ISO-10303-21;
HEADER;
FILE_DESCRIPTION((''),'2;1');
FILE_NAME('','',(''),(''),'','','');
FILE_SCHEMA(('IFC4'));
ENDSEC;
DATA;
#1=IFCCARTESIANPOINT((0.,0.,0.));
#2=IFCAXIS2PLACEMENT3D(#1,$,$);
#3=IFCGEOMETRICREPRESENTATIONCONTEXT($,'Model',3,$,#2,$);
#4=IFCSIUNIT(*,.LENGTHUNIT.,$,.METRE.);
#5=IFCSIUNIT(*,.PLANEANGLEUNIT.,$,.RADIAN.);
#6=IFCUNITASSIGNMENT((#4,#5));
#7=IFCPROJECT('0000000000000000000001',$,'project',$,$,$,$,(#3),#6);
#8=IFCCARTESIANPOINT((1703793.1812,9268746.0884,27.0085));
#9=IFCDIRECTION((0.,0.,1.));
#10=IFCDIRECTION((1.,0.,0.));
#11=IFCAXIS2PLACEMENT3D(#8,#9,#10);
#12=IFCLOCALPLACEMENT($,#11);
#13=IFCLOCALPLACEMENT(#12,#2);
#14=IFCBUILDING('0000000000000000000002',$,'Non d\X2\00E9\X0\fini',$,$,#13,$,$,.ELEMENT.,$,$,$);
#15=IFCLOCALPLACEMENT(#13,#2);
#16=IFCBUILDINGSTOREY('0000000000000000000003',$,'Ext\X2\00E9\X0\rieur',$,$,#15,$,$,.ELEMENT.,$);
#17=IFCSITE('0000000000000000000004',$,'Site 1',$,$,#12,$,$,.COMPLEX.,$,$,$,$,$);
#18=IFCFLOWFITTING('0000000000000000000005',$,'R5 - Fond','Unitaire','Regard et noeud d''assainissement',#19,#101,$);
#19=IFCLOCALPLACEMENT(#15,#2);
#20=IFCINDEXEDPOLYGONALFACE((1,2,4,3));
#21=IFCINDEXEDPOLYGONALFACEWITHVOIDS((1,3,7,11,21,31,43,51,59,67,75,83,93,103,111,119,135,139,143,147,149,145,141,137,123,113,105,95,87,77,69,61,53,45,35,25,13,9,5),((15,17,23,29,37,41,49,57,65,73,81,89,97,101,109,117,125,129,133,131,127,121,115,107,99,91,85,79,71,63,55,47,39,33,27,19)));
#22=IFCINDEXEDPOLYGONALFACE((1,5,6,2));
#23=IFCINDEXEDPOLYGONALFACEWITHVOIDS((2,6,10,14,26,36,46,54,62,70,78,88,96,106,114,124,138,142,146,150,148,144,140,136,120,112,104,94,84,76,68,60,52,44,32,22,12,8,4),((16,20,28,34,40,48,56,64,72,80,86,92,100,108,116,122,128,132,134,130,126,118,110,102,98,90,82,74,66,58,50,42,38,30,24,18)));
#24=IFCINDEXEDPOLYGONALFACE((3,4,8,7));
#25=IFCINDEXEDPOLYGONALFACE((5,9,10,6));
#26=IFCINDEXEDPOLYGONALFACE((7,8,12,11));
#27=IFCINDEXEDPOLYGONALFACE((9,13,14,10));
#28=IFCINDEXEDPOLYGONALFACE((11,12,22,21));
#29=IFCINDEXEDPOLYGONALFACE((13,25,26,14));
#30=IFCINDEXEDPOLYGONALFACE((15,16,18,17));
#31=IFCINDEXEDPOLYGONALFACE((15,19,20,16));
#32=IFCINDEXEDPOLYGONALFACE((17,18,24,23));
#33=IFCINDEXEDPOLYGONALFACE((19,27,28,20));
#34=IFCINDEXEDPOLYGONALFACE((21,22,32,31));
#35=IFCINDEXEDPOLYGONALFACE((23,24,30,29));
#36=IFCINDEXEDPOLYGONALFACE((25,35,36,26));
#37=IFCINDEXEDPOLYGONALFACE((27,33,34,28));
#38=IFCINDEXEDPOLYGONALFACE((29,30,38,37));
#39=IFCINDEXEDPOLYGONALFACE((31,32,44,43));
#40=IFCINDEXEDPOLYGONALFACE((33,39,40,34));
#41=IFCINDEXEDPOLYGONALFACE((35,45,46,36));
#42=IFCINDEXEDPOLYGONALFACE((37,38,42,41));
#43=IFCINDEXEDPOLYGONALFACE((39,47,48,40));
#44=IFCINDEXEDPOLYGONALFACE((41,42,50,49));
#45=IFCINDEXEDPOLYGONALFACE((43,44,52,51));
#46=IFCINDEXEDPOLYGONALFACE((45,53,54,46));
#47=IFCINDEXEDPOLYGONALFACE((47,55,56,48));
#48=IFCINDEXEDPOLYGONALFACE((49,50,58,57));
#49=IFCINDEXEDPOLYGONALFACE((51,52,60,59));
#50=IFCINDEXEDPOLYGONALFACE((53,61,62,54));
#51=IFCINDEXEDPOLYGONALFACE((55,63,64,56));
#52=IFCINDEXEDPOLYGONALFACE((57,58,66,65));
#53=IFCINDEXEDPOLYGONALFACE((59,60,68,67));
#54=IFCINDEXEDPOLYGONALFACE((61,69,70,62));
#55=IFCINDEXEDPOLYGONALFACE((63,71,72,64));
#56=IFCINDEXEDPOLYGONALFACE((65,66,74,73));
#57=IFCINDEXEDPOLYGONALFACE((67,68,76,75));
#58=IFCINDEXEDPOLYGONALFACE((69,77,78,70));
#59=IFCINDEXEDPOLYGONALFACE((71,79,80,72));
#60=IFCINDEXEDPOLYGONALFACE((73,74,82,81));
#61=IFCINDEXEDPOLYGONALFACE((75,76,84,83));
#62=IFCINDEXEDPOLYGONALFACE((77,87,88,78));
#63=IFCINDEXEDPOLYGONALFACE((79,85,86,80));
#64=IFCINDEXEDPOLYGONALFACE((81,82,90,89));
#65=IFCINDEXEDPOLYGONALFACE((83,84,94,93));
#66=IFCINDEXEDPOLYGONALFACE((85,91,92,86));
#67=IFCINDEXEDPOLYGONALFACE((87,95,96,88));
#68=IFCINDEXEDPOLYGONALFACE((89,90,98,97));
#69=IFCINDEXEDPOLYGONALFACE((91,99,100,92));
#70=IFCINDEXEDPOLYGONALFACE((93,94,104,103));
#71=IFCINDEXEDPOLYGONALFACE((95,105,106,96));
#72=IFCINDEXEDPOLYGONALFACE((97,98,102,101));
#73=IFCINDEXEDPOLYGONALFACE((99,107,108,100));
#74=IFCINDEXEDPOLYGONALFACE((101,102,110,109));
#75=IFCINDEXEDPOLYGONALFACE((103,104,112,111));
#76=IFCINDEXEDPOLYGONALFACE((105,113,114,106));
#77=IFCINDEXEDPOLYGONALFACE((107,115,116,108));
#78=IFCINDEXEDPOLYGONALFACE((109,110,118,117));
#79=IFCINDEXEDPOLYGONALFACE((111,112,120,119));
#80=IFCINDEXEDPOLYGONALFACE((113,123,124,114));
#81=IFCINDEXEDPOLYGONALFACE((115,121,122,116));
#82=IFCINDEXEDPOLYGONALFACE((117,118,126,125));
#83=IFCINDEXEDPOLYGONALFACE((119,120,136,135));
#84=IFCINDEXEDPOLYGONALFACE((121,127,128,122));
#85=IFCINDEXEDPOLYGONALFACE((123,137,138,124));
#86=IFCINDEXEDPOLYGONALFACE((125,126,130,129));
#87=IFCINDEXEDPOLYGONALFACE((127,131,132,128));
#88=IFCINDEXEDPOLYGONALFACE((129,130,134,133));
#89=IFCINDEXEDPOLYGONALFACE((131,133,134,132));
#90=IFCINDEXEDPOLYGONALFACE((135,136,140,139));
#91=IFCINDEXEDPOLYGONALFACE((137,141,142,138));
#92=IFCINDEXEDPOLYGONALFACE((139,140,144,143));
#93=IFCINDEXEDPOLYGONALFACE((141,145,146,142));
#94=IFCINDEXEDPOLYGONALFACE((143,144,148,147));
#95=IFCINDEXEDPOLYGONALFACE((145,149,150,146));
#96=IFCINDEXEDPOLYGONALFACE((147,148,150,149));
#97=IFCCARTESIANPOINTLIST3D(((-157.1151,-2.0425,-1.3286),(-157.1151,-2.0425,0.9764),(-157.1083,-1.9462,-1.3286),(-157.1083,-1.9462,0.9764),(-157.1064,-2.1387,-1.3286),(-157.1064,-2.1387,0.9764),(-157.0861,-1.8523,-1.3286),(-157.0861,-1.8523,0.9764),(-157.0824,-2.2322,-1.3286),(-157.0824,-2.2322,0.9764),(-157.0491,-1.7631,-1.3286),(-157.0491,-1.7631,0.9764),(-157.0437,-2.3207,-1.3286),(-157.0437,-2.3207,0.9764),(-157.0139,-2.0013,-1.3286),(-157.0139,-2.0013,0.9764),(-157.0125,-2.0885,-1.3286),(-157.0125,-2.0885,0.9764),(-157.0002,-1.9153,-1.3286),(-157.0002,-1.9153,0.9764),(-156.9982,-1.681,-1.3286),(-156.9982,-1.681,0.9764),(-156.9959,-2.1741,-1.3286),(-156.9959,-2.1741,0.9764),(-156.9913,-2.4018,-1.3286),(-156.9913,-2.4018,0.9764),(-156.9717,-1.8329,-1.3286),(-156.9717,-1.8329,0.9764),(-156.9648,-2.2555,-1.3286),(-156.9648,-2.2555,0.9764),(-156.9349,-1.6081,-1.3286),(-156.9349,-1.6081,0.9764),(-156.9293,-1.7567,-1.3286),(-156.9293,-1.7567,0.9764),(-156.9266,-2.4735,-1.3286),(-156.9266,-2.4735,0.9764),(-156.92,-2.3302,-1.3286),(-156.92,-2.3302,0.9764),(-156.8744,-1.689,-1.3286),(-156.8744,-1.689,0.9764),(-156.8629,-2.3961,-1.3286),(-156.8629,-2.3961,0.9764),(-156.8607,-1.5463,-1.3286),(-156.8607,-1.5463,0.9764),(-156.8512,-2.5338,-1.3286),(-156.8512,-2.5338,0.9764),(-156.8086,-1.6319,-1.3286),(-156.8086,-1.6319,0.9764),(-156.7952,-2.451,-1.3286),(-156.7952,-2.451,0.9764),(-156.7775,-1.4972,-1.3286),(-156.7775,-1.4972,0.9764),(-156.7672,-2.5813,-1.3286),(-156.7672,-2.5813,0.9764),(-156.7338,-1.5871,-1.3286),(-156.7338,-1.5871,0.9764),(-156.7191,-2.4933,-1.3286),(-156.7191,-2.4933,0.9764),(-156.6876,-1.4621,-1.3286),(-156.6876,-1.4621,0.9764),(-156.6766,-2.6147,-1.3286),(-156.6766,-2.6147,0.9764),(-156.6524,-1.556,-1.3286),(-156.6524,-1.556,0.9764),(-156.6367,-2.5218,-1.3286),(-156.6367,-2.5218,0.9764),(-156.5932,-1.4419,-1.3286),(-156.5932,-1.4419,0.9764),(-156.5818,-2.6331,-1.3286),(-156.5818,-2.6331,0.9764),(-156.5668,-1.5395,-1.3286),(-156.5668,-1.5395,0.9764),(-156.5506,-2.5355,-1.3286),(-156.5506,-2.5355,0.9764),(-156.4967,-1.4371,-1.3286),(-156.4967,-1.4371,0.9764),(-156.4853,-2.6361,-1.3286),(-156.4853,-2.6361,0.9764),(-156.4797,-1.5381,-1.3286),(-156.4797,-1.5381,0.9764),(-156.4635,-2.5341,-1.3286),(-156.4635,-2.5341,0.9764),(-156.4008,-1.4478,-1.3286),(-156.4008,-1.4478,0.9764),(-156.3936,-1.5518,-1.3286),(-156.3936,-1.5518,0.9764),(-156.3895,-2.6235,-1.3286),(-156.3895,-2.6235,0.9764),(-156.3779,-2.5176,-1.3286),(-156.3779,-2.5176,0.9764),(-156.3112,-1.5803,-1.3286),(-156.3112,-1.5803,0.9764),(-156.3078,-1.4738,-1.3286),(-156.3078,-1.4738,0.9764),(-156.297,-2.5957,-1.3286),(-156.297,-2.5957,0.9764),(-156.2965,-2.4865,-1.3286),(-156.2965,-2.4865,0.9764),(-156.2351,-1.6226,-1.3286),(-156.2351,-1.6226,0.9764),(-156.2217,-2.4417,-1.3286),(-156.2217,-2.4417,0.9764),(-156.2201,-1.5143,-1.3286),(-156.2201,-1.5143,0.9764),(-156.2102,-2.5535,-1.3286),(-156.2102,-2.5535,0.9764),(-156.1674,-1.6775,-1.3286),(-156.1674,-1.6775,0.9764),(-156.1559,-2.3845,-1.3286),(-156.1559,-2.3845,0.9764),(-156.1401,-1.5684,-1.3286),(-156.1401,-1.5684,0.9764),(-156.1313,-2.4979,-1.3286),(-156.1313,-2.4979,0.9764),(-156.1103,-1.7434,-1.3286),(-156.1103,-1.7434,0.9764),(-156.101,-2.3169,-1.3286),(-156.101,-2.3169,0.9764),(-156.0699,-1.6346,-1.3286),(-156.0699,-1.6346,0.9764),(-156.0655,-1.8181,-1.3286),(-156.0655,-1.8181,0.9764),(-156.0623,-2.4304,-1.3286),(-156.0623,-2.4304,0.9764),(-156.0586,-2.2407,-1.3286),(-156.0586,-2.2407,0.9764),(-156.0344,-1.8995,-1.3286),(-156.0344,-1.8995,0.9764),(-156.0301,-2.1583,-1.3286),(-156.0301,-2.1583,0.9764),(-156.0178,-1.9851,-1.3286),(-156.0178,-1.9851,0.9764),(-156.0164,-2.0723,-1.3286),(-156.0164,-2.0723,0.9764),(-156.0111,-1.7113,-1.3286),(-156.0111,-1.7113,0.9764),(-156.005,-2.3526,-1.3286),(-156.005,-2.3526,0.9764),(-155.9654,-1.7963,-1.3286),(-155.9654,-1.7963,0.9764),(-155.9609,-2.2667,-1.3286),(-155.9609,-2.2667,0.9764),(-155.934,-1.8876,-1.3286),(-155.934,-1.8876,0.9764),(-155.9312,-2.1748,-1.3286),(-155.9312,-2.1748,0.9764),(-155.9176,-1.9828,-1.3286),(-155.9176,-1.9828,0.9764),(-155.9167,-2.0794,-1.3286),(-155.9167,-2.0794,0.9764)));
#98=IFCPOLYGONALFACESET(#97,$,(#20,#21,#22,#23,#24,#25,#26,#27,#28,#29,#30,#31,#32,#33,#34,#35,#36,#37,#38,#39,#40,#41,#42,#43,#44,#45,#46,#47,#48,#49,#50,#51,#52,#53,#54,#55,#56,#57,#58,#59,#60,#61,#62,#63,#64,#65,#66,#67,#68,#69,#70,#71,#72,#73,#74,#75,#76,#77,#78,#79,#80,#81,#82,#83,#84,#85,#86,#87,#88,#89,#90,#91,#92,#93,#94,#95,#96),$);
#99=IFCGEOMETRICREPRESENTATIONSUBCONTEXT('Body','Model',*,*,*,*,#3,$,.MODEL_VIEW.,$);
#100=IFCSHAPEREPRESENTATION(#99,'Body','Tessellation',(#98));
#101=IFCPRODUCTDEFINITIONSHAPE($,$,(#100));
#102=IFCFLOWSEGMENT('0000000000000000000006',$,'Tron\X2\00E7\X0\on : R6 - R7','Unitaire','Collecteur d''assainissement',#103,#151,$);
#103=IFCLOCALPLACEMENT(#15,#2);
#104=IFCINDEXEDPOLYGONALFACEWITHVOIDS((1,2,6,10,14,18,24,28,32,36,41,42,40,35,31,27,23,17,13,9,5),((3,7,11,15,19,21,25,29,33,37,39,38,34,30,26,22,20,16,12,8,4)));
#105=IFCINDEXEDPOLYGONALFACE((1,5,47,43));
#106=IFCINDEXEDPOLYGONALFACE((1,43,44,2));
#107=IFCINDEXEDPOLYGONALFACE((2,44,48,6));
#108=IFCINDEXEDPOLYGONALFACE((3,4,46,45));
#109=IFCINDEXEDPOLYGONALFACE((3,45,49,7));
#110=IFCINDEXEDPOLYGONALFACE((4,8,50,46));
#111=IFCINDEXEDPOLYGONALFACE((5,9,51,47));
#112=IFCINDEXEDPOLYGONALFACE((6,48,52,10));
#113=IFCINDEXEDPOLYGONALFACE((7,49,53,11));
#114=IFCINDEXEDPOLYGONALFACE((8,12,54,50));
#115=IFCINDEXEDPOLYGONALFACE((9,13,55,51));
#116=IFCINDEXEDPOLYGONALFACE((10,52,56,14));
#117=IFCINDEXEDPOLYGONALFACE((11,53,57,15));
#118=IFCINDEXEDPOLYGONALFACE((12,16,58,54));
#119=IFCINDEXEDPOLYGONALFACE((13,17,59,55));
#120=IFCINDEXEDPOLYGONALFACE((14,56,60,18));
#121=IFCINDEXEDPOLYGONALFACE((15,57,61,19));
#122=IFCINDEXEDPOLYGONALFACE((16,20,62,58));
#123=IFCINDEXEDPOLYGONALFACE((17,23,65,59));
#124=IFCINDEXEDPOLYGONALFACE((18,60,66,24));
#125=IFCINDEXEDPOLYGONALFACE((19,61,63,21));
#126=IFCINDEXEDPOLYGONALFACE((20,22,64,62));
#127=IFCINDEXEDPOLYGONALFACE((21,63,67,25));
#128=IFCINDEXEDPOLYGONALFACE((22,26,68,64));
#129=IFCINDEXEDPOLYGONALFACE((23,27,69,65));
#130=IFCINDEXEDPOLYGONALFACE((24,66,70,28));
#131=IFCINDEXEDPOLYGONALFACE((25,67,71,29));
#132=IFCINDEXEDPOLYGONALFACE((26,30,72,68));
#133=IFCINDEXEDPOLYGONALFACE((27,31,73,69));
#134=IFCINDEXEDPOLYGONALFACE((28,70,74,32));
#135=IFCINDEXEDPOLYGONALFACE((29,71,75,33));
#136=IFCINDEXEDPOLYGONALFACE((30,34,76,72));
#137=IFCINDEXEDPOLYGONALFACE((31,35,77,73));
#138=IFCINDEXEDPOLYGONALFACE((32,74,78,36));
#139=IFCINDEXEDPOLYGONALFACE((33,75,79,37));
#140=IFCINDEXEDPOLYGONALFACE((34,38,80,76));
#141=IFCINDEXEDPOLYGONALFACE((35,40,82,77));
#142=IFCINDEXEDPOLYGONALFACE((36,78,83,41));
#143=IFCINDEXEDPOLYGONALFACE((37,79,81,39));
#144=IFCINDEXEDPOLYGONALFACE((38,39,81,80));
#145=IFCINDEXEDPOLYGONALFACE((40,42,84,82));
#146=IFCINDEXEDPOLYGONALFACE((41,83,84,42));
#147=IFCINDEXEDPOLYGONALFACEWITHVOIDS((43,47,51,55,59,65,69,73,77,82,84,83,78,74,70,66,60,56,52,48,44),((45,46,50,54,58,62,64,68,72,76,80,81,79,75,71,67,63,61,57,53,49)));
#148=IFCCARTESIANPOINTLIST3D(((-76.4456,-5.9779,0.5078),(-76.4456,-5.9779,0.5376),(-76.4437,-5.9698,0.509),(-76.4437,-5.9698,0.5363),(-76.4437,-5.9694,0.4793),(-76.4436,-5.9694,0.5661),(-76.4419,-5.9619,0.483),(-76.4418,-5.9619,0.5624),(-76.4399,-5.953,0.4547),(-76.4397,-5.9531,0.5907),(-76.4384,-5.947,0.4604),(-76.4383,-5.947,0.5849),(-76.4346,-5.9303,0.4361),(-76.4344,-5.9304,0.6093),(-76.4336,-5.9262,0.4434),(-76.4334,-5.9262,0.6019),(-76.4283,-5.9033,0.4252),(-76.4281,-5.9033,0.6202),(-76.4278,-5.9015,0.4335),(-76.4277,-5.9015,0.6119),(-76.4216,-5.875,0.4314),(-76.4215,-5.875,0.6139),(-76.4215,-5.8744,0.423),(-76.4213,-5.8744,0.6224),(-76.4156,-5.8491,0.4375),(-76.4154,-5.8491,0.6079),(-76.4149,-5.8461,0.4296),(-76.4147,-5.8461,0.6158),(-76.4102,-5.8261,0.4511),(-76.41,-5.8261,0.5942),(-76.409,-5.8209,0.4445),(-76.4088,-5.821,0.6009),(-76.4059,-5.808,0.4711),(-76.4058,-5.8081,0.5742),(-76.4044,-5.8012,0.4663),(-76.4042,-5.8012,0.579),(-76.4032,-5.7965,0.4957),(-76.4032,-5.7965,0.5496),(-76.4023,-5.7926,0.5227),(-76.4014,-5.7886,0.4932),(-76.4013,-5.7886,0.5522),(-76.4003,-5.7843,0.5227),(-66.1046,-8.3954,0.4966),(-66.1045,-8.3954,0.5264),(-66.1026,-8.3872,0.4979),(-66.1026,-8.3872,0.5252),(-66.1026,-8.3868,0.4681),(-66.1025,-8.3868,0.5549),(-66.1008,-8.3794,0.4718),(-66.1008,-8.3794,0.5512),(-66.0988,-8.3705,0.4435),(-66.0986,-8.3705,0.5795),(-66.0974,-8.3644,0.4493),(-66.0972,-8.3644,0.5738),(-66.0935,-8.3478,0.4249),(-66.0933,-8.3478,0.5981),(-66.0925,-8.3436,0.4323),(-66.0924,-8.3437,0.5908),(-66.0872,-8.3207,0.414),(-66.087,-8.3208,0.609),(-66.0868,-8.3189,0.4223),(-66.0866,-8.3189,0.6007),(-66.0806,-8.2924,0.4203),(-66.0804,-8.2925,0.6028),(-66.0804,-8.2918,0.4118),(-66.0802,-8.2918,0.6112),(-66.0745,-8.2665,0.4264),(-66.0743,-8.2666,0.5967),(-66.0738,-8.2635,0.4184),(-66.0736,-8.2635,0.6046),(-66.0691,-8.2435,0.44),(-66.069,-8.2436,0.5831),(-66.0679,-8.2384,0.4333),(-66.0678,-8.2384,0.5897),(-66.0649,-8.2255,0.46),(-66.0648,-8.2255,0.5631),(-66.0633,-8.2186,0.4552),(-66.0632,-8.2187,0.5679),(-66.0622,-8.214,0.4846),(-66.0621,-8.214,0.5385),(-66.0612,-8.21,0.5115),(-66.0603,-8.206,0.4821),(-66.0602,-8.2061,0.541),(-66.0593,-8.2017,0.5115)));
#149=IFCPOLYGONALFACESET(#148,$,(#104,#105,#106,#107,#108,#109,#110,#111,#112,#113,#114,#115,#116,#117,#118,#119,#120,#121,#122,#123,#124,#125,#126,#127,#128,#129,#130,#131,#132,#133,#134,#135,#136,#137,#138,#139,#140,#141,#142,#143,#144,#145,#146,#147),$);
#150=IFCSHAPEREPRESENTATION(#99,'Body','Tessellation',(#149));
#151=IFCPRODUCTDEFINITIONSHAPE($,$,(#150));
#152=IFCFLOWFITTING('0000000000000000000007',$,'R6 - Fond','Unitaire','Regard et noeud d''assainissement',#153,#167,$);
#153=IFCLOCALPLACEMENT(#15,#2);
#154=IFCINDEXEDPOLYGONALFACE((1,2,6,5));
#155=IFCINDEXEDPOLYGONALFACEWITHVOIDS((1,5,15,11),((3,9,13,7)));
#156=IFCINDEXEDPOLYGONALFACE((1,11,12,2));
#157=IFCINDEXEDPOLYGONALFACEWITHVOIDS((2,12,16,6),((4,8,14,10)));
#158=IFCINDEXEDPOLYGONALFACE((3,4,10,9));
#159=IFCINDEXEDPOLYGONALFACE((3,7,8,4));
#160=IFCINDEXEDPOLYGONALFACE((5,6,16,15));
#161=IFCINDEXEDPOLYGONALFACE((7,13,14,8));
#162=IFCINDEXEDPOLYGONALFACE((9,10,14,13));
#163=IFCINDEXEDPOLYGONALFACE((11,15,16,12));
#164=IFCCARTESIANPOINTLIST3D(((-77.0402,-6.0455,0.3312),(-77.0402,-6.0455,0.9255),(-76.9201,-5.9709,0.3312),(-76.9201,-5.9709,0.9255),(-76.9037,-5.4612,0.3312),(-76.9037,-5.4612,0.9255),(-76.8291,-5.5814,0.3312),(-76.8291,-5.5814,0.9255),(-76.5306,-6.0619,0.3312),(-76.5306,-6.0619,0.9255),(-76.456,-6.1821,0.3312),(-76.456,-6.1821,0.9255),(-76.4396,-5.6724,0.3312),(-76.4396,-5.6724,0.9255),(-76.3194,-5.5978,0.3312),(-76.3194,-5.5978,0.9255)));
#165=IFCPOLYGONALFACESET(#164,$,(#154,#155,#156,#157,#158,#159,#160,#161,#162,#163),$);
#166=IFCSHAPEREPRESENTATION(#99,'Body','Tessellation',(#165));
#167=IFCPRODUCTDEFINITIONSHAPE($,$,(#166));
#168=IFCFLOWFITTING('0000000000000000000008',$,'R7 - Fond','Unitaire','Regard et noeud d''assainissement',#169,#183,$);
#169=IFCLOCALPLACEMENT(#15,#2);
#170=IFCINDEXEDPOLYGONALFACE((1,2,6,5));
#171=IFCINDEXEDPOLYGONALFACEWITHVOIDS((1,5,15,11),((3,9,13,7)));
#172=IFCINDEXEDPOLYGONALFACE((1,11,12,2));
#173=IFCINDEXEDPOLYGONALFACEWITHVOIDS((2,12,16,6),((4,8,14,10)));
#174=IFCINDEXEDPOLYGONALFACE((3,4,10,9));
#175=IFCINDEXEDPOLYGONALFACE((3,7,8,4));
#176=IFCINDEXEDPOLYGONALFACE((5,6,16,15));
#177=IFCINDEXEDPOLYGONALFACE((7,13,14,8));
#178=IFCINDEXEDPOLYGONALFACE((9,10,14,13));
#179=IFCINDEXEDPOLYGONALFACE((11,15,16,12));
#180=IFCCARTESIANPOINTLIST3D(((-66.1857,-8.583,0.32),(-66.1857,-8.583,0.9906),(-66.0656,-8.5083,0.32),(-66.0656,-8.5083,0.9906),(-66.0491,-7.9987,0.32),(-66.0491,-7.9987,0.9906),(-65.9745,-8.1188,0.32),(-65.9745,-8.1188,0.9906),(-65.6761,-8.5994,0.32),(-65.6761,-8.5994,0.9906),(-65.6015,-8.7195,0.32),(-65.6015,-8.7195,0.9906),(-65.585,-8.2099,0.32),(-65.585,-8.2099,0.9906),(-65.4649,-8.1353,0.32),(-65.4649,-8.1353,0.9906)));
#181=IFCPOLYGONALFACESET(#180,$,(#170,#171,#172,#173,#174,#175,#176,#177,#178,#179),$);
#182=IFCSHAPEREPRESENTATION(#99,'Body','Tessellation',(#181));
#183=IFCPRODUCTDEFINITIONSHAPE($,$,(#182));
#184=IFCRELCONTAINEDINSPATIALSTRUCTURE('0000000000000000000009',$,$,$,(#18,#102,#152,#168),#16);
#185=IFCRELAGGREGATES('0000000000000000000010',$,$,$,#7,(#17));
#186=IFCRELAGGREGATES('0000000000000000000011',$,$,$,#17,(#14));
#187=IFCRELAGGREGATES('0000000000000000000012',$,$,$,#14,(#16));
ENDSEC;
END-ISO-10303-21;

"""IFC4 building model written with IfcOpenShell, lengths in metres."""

from ifc_helpers import new_model, si_unit, frame, origin, origin_2d, place, context, subcontext, project, spatial, hollow_rectangle, hollow_circle, extrude, element, save


model = new_model("IFC4")

# Units and contexts
model_context = context("Model", 3, world=origin())
body_context = subcontext(model_context, "Body", "Model", "MODEL_VIEW")
ifc_project = project(units=[si_unit("LENGTHUNIT", "METRE"), si_unit("PLANEANGLEUNIT", "RADIAN")], contexts=[model_context])

# Site, building, storey
site_placement = place(None, frame((1703793.1812, 9268746.0884, 27.0085), z_axis=(0.0, 0.0, 1.0), x_axis=(1.0, 0.0, 0.0)))
site = spatial("IfcSite", under=ifc_project, at=site_placement, Name="Site 1", CompositionType="COMPLEX")
building_placement = place(site_placement, origin())
building = spatial("IfcBuilding", under=site, at=building_placement, Name="Non défini", CompositionType="ELEMENT")
storey_placement = place(building_placement, origin())
storey = spatial("IfcBuildingStorey", under=building, at=storey_placement, Name="Extérieur", CompositionType="ELEMENT")

# Flow fitting
flow_fitting_1_placement = place(storey_placement, origin())
element("IfcFlowFitting", 1, at=flow_fitting_1_placement, inside=storey, Name="R5 - Fond", Description="Unitaire", ObjectType="Regard et noeud d'assainissement", context=body_context, shape_type="SweptSolid", body=[
    extrude(hollow_circle(Radius=0.6, WallThickness=0.1, at=origin_2d()), frame((-156.5151, -2.0368, -1.3286), z_axis=(0.0, 0.0, 1.0), x_axis=(0.997482, -0.070926, 0.0)), (0.0, 0.0, 1.0), 2.305),
])

# Flow segment
flow_segment_1_placement = place(storey_placement, origin())
element("IfcFlowSegment", 2, at=flow_segment_1_placement, inside=storey, Name="Tronçon : R6 - R7", Description="Unitaire", ObjectType="Collecteur d'assainissement", context=body_context, shape_type="SweptSolid", body=[
    extrude(hollow_circle(Radius=0.1, WallThickness=0.0085, at=origin_2d()), frame((-76.4231, -5.8817, 0.5227), z_axis=(0.973746, -0.227634, -0.00105), x_axis=(0.227634, 0.973747, 0.0)), (0.0, 0.0, 1.0), 10.6199),
])

# Flow fittings
flow_fitting_2_placement = place(storey_placement, origin())
element("IfcFlowFitting", 3, at=flow_fitting_2_placement, inside=storey, Name="R6 - Fond", Description="Unitaire", ObjectType="Regard et noeud d'assainissement", context=body_context, shape_type="SweptSolid", body=[
    extrude(hollow_rectangle(XDim=0.6, YDim=0.6, WallThickness=0.1, at=origin_2d()), frame((-76.6798, -5.8216, 0.3312), z_axis=(0.0, 0.0, 1.0), x_axis=(0.973747, -0.227634, 0.0)), (0.0, 0.0, 1.0), 0.5943),
])
flow_fitting_3_placement = place(storey_placement, origin())
element("IfcFlowFitting", 4, at=flow_fitting_3_placement, inside=storey, Name="R7 - Fond", Description="Unitaire", ObjectType="Regard et noeud d'assainissement", context=body_context, shape_type="SweptSolid", body=[
    extrude(hollow_rectangle(XDim=0.6, YDim=0.6, WallThickness=0.1, at=origin_2d()), frame((-65.8253, -8.3591, 0.32), z_axis=(0.0, 0.0, 1.0), x_axis=(0.973747, -0.227634, 0.0)), (0.0, 0.0, 1.0), 0.6706),
])

save(model, "model.ifc")
